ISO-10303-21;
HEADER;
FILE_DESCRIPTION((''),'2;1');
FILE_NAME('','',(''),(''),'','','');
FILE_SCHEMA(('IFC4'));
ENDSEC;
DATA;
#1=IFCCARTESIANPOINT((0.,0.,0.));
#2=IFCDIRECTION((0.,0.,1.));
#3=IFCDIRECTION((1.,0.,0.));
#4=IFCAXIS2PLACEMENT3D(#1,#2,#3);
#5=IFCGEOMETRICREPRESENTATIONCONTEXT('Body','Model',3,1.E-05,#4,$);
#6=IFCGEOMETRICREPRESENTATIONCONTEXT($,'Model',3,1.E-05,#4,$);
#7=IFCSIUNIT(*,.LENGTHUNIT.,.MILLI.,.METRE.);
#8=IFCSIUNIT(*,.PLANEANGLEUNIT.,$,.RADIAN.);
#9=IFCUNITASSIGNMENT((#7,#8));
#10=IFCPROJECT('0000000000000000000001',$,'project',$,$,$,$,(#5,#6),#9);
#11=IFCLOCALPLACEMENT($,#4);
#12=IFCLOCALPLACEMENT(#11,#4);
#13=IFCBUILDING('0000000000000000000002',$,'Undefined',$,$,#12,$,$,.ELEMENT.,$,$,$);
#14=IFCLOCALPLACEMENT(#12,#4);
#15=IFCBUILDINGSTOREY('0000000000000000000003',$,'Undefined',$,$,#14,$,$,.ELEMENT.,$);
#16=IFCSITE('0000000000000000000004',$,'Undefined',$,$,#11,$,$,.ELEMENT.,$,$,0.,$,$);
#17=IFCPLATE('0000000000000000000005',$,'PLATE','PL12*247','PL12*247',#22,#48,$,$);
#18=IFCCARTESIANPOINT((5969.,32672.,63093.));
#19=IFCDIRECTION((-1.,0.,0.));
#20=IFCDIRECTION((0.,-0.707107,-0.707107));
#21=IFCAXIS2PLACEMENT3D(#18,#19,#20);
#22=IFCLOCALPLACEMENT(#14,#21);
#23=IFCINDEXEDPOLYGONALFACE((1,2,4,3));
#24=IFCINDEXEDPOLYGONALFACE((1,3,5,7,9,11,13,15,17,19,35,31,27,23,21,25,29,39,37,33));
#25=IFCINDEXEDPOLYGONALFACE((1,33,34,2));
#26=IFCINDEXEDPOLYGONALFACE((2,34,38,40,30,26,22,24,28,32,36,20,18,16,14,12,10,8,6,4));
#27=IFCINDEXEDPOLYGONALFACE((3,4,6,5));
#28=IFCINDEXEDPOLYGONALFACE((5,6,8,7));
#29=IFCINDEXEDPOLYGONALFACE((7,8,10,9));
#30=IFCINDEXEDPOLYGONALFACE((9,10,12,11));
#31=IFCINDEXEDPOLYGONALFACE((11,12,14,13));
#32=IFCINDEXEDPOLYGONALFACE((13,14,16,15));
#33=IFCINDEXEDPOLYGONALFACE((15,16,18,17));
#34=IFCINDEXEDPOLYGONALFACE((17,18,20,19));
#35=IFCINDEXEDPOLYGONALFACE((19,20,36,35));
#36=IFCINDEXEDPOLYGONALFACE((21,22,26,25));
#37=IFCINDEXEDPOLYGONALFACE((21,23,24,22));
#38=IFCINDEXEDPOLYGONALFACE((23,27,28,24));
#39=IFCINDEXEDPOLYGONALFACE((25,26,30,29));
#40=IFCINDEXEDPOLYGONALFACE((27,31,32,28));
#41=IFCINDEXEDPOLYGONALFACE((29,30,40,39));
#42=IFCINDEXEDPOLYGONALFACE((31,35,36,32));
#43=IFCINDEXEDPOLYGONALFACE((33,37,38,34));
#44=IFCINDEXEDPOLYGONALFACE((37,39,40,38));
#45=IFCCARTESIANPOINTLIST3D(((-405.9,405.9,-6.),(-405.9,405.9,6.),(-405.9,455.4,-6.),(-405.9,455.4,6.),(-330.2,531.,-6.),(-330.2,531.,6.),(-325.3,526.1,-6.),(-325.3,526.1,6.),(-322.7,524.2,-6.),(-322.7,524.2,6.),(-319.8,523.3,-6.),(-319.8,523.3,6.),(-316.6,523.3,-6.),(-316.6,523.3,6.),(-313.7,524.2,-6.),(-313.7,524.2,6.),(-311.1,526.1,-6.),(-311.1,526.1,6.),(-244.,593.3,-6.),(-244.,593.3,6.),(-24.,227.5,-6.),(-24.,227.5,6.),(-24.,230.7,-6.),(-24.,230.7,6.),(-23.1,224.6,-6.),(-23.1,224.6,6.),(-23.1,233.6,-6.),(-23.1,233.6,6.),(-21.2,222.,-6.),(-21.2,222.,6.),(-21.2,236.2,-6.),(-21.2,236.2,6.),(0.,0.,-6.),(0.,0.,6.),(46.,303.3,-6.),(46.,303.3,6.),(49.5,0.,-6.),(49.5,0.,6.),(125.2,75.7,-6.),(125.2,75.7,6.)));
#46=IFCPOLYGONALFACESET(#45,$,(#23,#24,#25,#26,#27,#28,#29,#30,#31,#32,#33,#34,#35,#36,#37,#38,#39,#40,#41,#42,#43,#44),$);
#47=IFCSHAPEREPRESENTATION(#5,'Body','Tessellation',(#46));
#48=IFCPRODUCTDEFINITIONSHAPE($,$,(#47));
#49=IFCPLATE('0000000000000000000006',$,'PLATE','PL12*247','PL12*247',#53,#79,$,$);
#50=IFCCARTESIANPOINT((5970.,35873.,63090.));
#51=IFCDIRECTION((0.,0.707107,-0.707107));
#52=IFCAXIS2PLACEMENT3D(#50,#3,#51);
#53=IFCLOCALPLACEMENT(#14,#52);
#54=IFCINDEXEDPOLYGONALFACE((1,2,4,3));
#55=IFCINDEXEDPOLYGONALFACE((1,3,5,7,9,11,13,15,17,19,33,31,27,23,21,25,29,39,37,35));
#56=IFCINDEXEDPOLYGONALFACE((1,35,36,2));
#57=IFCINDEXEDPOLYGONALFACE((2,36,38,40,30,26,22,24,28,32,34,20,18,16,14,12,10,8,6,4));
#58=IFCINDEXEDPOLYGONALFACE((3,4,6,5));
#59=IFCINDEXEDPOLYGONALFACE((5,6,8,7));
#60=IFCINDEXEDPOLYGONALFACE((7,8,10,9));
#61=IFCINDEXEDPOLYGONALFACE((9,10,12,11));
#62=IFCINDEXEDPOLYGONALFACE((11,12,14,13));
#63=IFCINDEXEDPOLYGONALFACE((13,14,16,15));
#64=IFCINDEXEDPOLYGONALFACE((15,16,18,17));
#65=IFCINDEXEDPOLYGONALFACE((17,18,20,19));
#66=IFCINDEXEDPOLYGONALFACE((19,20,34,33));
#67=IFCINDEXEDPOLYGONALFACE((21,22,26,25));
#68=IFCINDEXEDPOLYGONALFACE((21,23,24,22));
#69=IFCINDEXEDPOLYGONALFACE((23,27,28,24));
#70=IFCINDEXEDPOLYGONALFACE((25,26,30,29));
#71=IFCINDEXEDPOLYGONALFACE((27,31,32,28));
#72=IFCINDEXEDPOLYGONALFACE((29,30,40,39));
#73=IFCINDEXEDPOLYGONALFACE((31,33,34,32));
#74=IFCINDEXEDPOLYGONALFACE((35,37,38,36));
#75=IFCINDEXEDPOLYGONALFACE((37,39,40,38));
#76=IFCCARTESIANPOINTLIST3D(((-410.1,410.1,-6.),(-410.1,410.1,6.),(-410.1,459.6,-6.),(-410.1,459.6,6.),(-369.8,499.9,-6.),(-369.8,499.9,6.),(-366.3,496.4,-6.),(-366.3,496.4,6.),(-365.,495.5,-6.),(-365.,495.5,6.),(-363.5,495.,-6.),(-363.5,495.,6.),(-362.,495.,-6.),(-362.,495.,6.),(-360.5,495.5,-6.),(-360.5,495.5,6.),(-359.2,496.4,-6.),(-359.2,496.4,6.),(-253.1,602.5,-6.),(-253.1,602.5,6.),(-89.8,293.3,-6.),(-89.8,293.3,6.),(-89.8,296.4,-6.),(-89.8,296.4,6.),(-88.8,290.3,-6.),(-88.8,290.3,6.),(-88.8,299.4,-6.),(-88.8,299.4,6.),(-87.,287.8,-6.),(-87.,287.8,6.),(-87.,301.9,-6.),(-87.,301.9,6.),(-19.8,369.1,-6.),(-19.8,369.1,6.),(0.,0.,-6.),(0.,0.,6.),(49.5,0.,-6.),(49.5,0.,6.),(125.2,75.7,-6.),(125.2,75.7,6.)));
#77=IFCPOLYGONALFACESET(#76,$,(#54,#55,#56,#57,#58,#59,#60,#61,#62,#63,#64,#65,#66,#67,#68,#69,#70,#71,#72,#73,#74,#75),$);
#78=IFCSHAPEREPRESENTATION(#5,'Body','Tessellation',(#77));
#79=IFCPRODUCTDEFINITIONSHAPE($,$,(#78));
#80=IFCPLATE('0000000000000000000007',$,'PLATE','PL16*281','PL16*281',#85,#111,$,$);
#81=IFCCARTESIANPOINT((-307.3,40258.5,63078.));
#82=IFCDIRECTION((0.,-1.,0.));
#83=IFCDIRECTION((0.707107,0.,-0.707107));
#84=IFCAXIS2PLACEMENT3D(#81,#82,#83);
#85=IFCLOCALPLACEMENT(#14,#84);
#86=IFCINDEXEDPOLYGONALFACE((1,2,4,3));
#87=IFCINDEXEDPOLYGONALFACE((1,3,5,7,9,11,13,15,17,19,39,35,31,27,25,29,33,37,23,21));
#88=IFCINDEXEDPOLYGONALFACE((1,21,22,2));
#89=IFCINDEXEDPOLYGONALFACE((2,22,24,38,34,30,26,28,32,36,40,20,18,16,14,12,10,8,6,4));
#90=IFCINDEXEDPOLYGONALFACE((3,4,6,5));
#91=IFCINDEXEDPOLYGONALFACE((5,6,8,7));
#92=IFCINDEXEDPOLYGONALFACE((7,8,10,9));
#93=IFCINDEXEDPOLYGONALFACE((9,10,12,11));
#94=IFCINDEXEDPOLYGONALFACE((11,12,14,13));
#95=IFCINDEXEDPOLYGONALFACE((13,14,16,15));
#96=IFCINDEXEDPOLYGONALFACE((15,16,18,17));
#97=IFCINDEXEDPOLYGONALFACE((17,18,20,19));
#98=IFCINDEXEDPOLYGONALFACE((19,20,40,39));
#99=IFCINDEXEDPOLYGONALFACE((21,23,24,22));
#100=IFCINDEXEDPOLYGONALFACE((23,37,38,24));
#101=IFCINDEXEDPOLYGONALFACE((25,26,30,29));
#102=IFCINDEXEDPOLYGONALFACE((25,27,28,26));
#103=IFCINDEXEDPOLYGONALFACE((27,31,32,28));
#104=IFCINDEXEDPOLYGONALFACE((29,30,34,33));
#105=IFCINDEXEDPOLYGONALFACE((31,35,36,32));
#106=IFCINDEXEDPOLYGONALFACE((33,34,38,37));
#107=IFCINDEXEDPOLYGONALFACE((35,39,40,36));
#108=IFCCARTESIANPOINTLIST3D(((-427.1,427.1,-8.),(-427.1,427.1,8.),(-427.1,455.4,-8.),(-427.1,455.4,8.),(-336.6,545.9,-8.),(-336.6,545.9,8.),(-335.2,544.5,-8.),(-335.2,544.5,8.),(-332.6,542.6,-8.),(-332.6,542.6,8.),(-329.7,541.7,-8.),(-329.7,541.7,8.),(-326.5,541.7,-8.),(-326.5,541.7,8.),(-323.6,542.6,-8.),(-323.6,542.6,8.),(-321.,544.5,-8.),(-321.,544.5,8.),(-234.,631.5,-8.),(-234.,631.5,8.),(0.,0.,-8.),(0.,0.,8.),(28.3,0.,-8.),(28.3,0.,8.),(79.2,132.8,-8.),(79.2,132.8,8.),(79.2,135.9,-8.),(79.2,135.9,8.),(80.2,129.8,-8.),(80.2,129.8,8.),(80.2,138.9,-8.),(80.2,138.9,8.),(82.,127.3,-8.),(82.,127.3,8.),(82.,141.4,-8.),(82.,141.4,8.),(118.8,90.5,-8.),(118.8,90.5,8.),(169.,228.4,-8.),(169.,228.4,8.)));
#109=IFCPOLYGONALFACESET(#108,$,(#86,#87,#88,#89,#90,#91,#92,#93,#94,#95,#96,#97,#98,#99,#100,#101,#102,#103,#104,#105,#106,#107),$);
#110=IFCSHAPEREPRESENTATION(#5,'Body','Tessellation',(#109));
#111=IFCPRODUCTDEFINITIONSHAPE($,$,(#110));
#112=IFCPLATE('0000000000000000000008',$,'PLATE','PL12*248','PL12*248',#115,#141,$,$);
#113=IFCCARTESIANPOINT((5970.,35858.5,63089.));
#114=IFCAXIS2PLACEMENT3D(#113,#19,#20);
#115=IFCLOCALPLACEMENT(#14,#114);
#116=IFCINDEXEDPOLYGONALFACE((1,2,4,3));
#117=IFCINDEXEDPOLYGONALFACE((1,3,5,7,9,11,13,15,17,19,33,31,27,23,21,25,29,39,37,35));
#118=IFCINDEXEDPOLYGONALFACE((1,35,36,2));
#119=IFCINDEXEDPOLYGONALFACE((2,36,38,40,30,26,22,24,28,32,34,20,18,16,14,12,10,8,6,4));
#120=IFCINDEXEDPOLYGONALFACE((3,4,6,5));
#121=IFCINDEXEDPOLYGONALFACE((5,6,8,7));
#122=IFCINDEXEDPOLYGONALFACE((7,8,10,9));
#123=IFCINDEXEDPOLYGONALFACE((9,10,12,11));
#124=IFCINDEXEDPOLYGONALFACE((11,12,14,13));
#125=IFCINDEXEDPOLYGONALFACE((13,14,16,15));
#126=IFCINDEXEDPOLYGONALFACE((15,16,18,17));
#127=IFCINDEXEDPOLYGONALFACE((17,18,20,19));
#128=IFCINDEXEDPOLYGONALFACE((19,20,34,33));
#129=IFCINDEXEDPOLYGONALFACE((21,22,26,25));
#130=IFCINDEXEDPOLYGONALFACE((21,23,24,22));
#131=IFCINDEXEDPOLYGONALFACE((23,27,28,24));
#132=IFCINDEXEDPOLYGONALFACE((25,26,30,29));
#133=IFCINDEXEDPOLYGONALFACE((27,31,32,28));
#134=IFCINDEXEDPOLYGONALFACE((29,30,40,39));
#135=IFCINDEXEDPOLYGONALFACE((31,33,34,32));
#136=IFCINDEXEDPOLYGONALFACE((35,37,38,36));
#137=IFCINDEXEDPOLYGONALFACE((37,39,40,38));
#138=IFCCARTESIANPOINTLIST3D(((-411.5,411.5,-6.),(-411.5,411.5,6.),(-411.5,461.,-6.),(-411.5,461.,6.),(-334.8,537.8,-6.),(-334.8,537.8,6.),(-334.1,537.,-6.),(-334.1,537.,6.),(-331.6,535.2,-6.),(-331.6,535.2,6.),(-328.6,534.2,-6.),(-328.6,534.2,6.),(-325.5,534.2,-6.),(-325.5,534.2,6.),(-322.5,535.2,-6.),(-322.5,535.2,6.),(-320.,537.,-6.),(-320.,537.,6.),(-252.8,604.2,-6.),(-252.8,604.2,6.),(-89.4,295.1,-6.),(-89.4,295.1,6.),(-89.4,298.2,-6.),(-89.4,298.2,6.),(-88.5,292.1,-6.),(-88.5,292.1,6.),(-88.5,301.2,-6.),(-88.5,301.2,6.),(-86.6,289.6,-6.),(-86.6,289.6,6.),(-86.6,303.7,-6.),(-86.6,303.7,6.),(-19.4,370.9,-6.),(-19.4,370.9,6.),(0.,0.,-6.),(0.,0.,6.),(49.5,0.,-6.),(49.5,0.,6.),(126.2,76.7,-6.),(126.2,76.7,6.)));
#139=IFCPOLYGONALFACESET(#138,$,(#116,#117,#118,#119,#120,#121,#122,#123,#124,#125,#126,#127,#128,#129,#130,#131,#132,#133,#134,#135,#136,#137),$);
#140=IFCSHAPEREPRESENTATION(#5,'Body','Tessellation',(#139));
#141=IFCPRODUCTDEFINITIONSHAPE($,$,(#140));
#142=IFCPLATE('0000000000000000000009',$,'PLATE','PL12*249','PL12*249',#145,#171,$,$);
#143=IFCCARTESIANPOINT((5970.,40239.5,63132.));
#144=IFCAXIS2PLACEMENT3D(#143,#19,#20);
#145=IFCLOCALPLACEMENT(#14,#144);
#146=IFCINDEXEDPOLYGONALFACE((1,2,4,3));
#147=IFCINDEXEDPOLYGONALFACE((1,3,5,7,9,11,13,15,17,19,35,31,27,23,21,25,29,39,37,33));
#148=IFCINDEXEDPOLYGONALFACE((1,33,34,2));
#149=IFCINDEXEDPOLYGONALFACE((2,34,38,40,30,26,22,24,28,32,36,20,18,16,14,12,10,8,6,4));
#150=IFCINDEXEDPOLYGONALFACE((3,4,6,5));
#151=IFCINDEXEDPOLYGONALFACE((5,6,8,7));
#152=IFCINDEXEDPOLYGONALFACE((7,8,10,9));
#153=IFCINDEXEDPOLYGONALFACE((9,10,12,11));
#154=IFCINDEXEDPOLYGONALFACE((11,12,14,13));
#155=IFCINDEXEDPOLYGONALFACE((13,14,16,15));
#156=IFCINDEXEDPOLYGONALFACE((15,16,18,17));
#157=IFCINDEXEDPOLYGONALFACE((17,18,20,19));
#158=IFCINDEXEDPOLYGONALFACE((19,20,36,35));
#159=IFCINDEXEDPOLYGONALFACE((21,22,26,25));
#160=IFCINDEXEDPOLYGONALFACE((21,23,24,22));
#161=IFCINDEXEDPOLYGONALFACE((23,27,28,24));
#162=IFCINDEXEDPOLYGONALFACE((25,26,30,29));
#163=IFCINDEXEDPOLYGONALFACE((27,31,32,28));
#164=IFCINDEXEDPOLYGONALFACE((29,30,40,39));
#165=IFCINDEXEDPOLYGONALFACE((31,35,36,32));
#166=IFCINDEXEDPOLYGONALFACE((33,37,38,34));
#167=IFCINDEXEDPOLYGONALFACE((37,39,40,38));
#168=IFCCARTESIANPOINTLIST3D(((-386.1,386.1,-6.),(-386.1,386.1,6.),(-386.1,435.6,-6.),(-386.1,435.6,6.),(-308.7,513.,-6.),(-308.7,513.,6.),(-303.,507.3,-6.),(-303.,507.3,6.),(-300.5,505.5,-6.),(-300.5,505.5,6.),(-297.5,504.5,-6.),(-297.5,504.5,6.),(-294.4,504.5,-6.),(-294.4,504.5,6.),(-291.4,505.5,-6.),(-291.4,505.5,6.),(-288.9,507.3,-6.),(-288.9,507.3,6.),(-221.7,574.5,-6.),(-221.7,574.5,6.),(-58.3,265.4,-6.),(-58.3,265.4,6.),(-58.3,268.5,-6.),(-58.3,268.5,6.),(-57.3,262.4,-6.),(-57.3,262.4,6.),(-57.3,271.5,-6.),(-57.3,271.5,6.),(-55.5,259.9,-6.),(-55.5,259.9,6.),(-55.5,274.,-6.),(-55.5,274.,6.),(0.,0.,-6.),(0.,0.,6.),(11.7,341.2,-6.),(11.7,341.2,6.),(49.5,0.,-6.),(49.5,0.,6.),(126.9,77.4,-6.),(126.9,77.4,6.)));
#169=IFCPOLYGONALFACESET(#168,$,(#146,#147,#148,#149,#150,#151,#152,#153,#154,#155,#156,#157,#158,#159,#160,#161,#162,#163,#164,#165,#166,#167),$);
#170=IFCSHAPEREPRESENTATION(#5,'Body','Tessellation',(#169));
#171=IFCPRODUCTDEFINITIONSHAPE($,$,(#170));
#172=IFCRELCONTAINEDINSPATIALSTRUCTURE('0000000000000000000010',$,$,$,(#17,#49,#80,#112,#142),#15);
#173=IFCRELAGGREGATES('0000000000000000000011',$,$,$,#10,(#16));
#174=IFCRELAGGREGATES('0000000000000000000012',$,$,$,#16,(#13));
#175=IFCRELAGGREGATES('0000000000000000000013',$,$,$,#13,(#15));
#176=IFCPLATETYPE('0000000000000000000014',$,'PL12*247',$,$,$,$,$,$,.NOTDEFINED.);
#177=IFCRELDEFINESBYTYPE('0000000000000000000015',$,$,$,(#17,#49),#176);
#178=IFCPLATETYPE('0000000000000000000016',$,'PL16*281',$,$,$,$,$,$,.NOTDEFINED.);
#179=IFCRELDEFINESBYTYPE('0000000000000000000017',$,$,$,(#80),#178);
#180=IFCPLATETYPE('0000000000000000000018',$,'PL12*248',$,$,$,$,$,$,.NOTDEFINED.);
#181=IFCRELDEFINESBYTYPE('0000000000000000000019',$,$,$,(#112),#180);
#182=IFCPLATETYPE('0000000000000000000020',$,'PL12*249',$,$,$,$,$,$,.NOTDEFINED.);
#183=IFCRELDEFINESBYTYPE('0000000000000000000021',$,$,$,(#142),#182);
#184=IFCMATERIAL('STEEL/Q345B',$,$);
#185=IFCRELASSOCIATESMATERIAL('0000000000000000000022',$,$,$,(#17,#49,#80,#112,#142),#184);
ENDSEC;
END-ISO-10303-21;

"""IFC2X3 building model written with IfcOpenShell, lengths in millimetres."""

from ifc_helpers import new_model, si_unit, frame, origin_with_axes, place, context, project, spatial, polyline, outline, extrude, material, type_object, element, save


model = new_model("IFC2X3")

# Units and contexts
model_context_1 = context("Model", 3, precision=1e-05, world=origin_with_axes(), identifier="Body")
model_context_2 = context("Model", 3, precision=1e-05, world=origin_with_axes())
ifc_project = project(units=[si_unit("LENGTHUNIT", "METRE", prefix="MILLI"), si_unit("PLANEANGLEUNIT", "RADIAN")], contexts=[model_context_1, model_context_2])

# Site, building, storey
site_placement = place(None, origin_with_axes())
site = spatial("IfcSite", under=ifc_project, at=site_placement, Name="Undefined", CompositionType="ELEMENT", RefElevation=0.0)
building_placement = place(site_placement, origin_with_axes())
building = spatial("IfcBuilding", under=site, at=building_placement, Name="Undefined", CompositionType="ELEMENT")
storey_placement = place(building_placement, origin_with_axes())
storey = spatial("IfcBuildingStorey", under=building, at=storey_placement, Name="Undefined", CompositionType="ELEMENT")

# Shared definitions
ifc_material_1 = material(Name="STEEL/Q345B")

# Plates
plate_type_1 = type_object("IfcPlateType", Name="PL12*247", PredefinedType="NOTDEFINED")
for number, where, z_axis, x_axis, name in (
    (1, (5969.0, 32672.0, 63093.0), (-1.0, 0.0, 0.0), (0.0, -0.707107, -0.707107), "PLATE"),
):
    element("IfcPlate", number, at=place(storey_placement, frame(where, z_axis=z_axis, x_axis=x_axis)), inside=storey, type_object=plate_type_1, material=ifc_material_1, Name=name, Description="PL12*247", ObjectType="PL12*247", context=model_context_1, shape_type="SweptSolid", body=[
        extrude(outline(polyline([(0.0, 0.0), (49.5, 0.0), (125.2, 75.7), (-21.2, 222.0), (-23.1, 224.6), (-24.0, 227.5), (-24.0, 230.7), (-23.1, 233.6), (-21.2, 236.2), (46.0, 303.3), (-244.0, 593.3), (-311.1, 526.1), (-313.7, 524.2), (-316.6, 523.3), (-319.8, 523.3), (-322.7, 524.2), (-325.3, 526.1), (-330.2, 531.0), (-405.9, 455.4), (-405.9, 405.9), (0.0, 0.0)])), frame((0.0, 0.0, -6.0), z_axis=(0.0, 0.0, 1.0), x_axis=(1.0, 0.0, 0.0)), (0.0, 0.0, 1.0), 12.0),
    ])
plate_1_placement = place(storey_placement, frame((5970.0, 35873.0, 63090.0), z_axis=(1.0, 0.0, 0.0), x_axis=(0.0, 0.707107, -0.707107)))
element("IfcPlate", 2, at=plate_1_placement, inside=storey, type_object=plate_type_1, material=ifc_material_1, Name="PLATE", Description="PL12*247", ObjectType="PL12*247", context=model_context_1, shape_type="SweptSolid", body=[
    extrude(outline(polyline([(0.0, 0.0), (49.5, 0.0), (125.2, 75.7), (-87.0, 287.8), (-88.8, 290.3), (-89.8, 293.3), (-89.8, 296.4), (-88.8, 299.4), (-87.0, 301.9), (-19.8, 369.1), (-253.1, 602.5), (-359.2, 496.4), (-360.5, 495.5), (-362.0, 495.0), (-363.5, 495.0), (-365.0, 495.5), (-366.3, 496.4), (-369.8, 499.9), (-410.1, 459.6), (-410.1, 410.1), (0.0, 0.0)])), frame((0.0, 0.0, -6.0), z_axis=(0.0, 0.0, 1.0), x_axis=(1.0, 0.0, 0.0)), (0.0, 0.0, 1.0), 12.0),
])
plate_type_2 = type_object("IfcPlateType", Name="PL16*281", PredefinedType="NOTDEFINED")
plate_2_placement = place(storey_placement, frame((-307.3, 40258.5, 63078.0), z_axis=(0.0, -1.0, 0.0), x_axis=(0.707107, 0.0, -0.707107)))
element("IfcPlate", 3, at=plate_2_placement, inside=storey, type_object=plate_type_2, material=ifc_material_1, Name="PLATE", Description="PL16*281", ObjectType="PL16*281", context=model_context_1, shape_type="SweptSolid", body=[
    extrude(outline(polyline([(0.0, 0.0), (28.3, 0.0), (118.8, 90.5), (82.0, 127.3), (80.2, 129.8), (79.2, 132.8), (79.2, 135.9), (80.2, 138.9), (82.0, 141.4), (169.0, 228.4), (-234.0, 631.5), (-321.0, 544.5), (-323.6, 542.6), (-326.5, 541.7), (-329.7, 541.7), (-332.6, 542.6), (-335.2, 544.5), (-336.6, 545.9), (-427.1, 455.4), (-427.1, 427.1), (0.0, 0.0)])), frame((0.0, 0.0, -8.0), z_axis=(0.0, 0.0, 1.0), x_axis=(1.0, 0.0, 0.0)), (0.0, 0.0, 1.0), 16.0),
])
plate_type_3 = type_object("IfcPlateType", Name="PL12*248", PredefinedType="NOTDEFINED")
for number, where, z_axis, x_axis, name in (
    (4, (5970.0, 35858.5, 63089.0), (-1.0, 0.0, 0.0), (0.0, -0.707107, -0.707107), "PLATE"),
):
    element("IfcPlate", number, at=place(storey_placement, frame(where, z_axis=z_axis, x_axis=x_axis)), inside=storey, type_object=plate_type_3, material=ifc_material_1, Name=name, Description="PL12*248", ObjectType="PL12*248", context=model_context_1, shape_type="SweptSolid", body=[
        extrude(outline(polyline([(0.0, 0.0), (49.5, 0.0), (126.2, 76.7), (-86.6, 289.6), (-88.5, 292.1), (-89.4, 295.1), (-89.4, 298.2), (-88.5, 301.2), (-86.6, 303.7), (-19.4, 370.9), (-252.8, 604.2), (-320.0, 537.0), (-322.5, 535.2), (-325.5, 534.2), (-328.6, 534.2), (-331.6, 535.2), (-334.1, 537.0), (-334.8, 537.8), (-411.5, 461.0), (-411.5, 411.5), (0.0, 0.0)])), frame((0.0, 0.0, -6.0), z_axis=(0.0, 0.0, 1.0), x_axis=(1.0, 0.0, 0.0)), (0.0, 0.0, 1.0), 12.0),
    ])
plate_type_4 = type_object("IfcPlateType", Name="PL12*249", PredefinedType="NOTDEFINED")
for number, where, z_axis, x_axis, name in (
    (5, (5970.0, 40239.5, 63132.0), (-1.0, 0.0, 0.0), (0.0, -0.707107, -0.707107), "PLATE"),
):
    element("IfcPlate", number, at=place(storey_placement, frame(where, z_axis=z_axis, x_axis=x_axis)), inside=storey, type_object=plate_type_4, material=ifc_material_1, Name=name, Description="PL12*249", ObjectType="PL12*249", context=model_context_1, shape_type="SweptSolid", body=[
        extrude(outline(polyline([(0.0, 0.0), (49.5, 0.0), (126.9, 77.4), (-55.5, 259.9), (-57.3, 262.4), (-58.3, 265.4), (-58.3, 268.5), (-57.3, 271.5), (-55.5, 274.0), (11.7, 341.2), (-221.7, 574.5), (-288.9, 507.3), (-291.4, 505.5), (-294.4, 504.5), (-297.5, 504.5), (-300.5, 505.5), (-303.0, 507.3), (-308.7, 513.0), (-386.1, 435.6), (-386.1, 386.1), (0.0, 0.0)])), frame((0.0, 0.0, -6.0), z_axis=(0.0, 0.0, 1.0), x_axis=(1.0, 0.0, 0.0)), (0.0, 0.0, 1.0), 12.0),
    ])

save(model, "model.ifc")
